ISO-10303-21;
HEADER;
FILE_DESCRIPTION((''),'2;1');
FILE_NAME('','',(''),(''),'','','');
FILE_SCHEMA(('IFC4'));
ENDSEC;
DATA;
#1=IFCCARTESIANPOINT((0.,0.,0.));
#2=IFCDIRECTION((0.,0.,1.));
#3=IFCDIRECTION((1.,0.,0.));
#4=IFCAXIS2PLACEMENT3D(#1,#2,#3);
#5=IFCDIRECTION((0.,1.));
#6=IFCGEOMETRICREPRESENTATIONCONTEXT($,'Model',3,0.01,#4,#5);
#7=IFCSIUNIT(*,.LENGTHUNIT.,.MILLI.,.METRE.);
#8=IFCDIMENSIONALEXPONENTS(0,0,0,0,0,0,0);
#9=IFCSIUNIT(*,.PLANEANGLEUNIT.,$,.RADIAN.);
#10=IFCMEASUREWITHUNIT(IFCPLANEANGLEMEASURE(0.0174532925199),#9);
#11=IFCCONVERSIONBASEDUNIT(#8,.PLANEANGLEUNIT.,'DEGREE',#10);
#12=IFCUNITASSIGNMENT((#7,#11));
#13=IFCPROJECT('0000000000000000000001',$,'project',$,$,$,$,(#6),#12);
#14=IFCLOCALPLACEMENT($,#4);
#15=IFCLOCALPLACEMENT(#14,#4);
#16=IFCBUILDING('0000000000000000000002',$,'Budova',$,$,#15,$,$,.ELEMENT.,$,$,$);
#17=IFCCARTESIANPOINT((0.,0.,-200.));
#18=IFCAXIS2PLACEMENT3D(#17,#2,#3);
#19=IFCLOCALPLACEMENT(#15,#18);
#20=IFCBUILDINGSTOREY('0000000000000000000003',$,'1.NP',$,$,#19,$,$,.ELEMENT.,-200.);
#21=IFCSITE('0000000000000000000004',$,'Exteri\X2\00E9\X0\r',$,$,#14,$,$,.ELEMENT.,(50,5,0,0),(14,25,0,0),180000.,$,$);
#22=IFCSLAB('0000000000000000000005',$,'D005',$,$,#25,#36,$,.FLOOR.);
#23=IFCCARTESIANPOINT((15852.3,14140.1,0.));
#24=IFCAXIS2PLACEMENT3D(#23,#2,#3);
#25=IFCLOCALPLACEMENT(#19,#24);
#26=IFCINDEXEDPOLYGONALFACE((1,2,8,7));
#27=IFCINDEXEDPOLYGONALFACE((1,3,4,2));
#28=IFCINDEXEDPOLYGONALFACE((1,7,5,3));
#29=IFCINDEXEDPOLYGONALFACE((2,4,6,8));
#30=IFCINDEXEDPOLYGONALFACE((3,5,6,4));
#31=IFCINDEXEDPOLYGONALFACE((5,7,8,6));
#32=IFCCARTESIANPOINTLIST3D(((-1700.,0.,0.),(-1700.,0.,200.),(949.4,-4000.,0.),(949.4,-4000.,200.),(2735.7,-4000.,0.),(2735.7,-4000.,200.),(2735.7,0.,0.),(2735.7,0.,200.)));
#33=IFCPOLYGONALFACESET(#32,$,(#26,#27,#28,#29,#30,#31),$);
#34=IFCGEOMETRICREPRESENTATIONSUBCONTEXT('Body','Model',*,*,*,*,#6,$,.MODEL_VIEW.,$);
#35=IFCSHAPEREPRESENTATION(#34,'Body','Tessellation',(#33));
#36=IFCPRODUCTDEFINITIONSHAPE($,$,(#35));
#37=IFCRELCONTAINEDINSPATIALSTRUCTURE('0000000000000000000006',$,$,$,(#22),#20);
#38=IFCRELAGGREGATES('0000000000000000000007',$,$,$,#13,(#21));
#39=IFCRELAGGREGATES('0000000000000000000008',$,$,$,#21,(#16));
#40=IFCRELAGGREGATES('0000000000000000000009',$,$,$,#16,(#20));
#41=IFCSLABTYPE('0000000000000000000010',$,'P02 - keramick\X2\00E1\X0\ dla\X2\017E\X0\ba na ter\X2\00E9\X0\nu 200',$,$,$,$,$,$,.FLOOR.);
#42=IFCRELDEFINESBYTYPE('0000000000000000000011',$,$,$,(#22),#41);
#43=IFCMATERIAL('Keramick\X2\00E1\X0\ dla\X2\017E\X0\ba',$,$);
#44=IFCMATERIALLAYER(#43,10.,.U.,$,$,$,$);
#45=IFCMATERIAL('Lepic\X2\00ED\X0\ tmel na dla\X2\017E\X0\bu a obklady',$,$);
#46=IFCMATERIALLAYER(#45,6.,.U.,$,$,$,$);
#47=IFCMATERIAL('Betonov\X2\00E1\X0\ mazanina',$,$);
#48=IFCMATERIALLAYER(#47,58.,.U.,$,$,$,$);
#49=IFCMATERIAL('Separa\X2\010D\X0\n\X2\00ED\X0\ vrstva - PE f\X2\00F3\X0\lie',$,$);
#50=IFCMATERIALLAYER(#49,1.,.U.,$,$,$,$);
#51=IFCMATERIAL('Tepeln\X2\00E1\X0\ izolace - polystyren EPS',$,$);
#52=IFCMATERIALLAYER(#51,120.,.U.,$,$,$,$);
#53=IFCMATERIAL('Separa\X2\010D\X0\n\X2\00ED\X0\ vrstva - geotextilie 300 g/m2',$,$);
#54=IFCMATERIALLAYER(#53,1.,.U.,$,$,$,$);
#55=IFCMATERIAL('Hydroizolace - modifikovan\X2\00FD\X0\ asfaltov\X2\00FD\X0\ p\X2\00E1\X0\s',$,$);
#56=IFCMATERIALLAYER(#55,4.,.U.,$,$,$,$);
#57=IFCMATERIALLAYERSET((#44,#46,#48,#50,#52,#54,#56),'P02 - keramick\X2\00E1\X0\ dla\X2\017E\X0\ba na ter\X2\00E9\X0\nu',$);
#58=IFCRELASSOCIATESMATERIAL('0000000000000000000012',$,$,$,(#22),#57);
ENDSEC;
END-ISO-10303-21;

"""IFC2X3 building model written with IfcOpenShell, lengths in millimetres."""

from ifc_helpers import new_model, entity, si_unit, converted_unit, direction, frame, origin_with_axes, place, context, subcontext, project, spatial, polyline, outline, extrude, material, layer, layer_set, layer_usage, type_object, element, save


model = new_model("IFC2X3")

# Units and contexts
model_context = context("Model", 3, precision=0.01, world=origin_with_axes(), true_north=direction((0.0, 1.0)))
body_context = subcontext(model_context, "Body", "Model", "MODEL_VIEW")
ifc_project = project(units=[si_unit("LENGTHUNIT", "METRE", prefix="MILLI"), converted_unit("PLANEANGLEUNIT", "DEGREE", entity("IfcPlaneAngleMeasure", 0.0174532925199), si_unit("PLANEANGLEUNIT", "RADIAN"), dimensions=[0, 0, 0, 0, 0, 0, 0])], contexts=[model_context])

# Site, building, storey
site_placement = place(None, origin_with_axes())
site = spatial("IfcSite", under=ifc_project, at=site_placement, Name="Exteriér", CompositionType="ELEMENT", RefLatitude=(50, 5, 0, 0), RefLongitude=(14, 25, 0, 0), RefElevation=180000.0)
building_placement = place(site_placement, origin_with_axes())
building = spatial("IfcBuilding", under=site, at=building_placement, Name="Budova", CompositionType="ELEMENT")
storey_placement = place(building_placement, frame((0.0, 0.0, -200.0), z_axis=(0.0, 0.0, 1.0), x_axis=(1.0, 0.0, 0.0)))
storey = spatial("IfcBuildingStorey", under=building, at=storey_placement, Name="1.NP", CompositionType="ELEMENT", Elevation=-200.0)

# Slab
ifc_material_1 = material(Name="Betonová mazanina")
ifc_material_2 = material(Name="Separační vrstva - PE fólie")
ifc_material_3 = material(Name="Tepelná izolace - polystyren EPS")
ifc_material_4 = material(Name="Separační vrstva - geotextilie 300 g/m2")
ifc_material_5 = material(Name="Hydroizolace - modifikovaný asfaltový pás")
ifc_material_6 = material(Name="Keramická dlažba")
ifc_layer_1 = layer(ifc_material_6, 10.0, ventilated="UNKNOWN")
ifc_material_7 = material(Name="Lepicí tmel na dlažbu a obklady")
ifc_layer_2 = layer(ifc_material_7, 6.0, ventilated="UNKNOWN")
ifc_layer_3 = layer(ifc_material_1, 58.0, ventilated="UNKNOWN")
ifc_layer_4 = layer(ifc_material_2, 1.0, ventilated="UNKNOWN")
ifc_layer_5 = layer(ifc_material_3, 120.0, ventilated="UNKNOWN")
ifc_layer_6 = layer(ifc_material_4, 1.0, ventilated="UNKNOWN")
ifc_layer_7 = layer(ifc_material_5, 4.0, ventilated="UNKNOWN")
ifc_layer_set_1 = layer_set([ifc_layer_1, ifc_layer_2, ifc_layer_3, ifc_layer_4, ifc_layer_5, ifc_layer_6, ifc_layer_7], Name="P02 - keramická dlažba na terénu")
ifc_layer_usage_1 = layer_usage(ifc_layer_set_1, "AXIS3", "NEGATIVE", 200.0)
slab_type_1 = type_object("IfcSlabType", Name="P02 - keramická dlažba na terénu 200", PredefinedType="FLOOR")
slab_1_placement = place(storey_placement, frame((15852.3, 14140.1, 0.0), z_axis=(0.0, 0.0, 1.0), x_axis=(1.0, 0.0, 0.0)))
element("IfcSlab", 1, at=slab_1_placement, inside=storey, type_object=slab_type_1, material=ifc_layer_usage_1, Name="D005", PredefinedType="FLOOR", context=body_context, shape_type="SweptSolid", body=[
    extrude(outline(polyline([(-1700.0, 0.0), (949.4, -4000.0), (2735.7, -4000.0), (2735.7, 0.0), (-1700.0, 0.0)])), origin_with_axes(), (0.0, 0.0, 1.0), 200.0),
])

save(model, "model.ifc")
